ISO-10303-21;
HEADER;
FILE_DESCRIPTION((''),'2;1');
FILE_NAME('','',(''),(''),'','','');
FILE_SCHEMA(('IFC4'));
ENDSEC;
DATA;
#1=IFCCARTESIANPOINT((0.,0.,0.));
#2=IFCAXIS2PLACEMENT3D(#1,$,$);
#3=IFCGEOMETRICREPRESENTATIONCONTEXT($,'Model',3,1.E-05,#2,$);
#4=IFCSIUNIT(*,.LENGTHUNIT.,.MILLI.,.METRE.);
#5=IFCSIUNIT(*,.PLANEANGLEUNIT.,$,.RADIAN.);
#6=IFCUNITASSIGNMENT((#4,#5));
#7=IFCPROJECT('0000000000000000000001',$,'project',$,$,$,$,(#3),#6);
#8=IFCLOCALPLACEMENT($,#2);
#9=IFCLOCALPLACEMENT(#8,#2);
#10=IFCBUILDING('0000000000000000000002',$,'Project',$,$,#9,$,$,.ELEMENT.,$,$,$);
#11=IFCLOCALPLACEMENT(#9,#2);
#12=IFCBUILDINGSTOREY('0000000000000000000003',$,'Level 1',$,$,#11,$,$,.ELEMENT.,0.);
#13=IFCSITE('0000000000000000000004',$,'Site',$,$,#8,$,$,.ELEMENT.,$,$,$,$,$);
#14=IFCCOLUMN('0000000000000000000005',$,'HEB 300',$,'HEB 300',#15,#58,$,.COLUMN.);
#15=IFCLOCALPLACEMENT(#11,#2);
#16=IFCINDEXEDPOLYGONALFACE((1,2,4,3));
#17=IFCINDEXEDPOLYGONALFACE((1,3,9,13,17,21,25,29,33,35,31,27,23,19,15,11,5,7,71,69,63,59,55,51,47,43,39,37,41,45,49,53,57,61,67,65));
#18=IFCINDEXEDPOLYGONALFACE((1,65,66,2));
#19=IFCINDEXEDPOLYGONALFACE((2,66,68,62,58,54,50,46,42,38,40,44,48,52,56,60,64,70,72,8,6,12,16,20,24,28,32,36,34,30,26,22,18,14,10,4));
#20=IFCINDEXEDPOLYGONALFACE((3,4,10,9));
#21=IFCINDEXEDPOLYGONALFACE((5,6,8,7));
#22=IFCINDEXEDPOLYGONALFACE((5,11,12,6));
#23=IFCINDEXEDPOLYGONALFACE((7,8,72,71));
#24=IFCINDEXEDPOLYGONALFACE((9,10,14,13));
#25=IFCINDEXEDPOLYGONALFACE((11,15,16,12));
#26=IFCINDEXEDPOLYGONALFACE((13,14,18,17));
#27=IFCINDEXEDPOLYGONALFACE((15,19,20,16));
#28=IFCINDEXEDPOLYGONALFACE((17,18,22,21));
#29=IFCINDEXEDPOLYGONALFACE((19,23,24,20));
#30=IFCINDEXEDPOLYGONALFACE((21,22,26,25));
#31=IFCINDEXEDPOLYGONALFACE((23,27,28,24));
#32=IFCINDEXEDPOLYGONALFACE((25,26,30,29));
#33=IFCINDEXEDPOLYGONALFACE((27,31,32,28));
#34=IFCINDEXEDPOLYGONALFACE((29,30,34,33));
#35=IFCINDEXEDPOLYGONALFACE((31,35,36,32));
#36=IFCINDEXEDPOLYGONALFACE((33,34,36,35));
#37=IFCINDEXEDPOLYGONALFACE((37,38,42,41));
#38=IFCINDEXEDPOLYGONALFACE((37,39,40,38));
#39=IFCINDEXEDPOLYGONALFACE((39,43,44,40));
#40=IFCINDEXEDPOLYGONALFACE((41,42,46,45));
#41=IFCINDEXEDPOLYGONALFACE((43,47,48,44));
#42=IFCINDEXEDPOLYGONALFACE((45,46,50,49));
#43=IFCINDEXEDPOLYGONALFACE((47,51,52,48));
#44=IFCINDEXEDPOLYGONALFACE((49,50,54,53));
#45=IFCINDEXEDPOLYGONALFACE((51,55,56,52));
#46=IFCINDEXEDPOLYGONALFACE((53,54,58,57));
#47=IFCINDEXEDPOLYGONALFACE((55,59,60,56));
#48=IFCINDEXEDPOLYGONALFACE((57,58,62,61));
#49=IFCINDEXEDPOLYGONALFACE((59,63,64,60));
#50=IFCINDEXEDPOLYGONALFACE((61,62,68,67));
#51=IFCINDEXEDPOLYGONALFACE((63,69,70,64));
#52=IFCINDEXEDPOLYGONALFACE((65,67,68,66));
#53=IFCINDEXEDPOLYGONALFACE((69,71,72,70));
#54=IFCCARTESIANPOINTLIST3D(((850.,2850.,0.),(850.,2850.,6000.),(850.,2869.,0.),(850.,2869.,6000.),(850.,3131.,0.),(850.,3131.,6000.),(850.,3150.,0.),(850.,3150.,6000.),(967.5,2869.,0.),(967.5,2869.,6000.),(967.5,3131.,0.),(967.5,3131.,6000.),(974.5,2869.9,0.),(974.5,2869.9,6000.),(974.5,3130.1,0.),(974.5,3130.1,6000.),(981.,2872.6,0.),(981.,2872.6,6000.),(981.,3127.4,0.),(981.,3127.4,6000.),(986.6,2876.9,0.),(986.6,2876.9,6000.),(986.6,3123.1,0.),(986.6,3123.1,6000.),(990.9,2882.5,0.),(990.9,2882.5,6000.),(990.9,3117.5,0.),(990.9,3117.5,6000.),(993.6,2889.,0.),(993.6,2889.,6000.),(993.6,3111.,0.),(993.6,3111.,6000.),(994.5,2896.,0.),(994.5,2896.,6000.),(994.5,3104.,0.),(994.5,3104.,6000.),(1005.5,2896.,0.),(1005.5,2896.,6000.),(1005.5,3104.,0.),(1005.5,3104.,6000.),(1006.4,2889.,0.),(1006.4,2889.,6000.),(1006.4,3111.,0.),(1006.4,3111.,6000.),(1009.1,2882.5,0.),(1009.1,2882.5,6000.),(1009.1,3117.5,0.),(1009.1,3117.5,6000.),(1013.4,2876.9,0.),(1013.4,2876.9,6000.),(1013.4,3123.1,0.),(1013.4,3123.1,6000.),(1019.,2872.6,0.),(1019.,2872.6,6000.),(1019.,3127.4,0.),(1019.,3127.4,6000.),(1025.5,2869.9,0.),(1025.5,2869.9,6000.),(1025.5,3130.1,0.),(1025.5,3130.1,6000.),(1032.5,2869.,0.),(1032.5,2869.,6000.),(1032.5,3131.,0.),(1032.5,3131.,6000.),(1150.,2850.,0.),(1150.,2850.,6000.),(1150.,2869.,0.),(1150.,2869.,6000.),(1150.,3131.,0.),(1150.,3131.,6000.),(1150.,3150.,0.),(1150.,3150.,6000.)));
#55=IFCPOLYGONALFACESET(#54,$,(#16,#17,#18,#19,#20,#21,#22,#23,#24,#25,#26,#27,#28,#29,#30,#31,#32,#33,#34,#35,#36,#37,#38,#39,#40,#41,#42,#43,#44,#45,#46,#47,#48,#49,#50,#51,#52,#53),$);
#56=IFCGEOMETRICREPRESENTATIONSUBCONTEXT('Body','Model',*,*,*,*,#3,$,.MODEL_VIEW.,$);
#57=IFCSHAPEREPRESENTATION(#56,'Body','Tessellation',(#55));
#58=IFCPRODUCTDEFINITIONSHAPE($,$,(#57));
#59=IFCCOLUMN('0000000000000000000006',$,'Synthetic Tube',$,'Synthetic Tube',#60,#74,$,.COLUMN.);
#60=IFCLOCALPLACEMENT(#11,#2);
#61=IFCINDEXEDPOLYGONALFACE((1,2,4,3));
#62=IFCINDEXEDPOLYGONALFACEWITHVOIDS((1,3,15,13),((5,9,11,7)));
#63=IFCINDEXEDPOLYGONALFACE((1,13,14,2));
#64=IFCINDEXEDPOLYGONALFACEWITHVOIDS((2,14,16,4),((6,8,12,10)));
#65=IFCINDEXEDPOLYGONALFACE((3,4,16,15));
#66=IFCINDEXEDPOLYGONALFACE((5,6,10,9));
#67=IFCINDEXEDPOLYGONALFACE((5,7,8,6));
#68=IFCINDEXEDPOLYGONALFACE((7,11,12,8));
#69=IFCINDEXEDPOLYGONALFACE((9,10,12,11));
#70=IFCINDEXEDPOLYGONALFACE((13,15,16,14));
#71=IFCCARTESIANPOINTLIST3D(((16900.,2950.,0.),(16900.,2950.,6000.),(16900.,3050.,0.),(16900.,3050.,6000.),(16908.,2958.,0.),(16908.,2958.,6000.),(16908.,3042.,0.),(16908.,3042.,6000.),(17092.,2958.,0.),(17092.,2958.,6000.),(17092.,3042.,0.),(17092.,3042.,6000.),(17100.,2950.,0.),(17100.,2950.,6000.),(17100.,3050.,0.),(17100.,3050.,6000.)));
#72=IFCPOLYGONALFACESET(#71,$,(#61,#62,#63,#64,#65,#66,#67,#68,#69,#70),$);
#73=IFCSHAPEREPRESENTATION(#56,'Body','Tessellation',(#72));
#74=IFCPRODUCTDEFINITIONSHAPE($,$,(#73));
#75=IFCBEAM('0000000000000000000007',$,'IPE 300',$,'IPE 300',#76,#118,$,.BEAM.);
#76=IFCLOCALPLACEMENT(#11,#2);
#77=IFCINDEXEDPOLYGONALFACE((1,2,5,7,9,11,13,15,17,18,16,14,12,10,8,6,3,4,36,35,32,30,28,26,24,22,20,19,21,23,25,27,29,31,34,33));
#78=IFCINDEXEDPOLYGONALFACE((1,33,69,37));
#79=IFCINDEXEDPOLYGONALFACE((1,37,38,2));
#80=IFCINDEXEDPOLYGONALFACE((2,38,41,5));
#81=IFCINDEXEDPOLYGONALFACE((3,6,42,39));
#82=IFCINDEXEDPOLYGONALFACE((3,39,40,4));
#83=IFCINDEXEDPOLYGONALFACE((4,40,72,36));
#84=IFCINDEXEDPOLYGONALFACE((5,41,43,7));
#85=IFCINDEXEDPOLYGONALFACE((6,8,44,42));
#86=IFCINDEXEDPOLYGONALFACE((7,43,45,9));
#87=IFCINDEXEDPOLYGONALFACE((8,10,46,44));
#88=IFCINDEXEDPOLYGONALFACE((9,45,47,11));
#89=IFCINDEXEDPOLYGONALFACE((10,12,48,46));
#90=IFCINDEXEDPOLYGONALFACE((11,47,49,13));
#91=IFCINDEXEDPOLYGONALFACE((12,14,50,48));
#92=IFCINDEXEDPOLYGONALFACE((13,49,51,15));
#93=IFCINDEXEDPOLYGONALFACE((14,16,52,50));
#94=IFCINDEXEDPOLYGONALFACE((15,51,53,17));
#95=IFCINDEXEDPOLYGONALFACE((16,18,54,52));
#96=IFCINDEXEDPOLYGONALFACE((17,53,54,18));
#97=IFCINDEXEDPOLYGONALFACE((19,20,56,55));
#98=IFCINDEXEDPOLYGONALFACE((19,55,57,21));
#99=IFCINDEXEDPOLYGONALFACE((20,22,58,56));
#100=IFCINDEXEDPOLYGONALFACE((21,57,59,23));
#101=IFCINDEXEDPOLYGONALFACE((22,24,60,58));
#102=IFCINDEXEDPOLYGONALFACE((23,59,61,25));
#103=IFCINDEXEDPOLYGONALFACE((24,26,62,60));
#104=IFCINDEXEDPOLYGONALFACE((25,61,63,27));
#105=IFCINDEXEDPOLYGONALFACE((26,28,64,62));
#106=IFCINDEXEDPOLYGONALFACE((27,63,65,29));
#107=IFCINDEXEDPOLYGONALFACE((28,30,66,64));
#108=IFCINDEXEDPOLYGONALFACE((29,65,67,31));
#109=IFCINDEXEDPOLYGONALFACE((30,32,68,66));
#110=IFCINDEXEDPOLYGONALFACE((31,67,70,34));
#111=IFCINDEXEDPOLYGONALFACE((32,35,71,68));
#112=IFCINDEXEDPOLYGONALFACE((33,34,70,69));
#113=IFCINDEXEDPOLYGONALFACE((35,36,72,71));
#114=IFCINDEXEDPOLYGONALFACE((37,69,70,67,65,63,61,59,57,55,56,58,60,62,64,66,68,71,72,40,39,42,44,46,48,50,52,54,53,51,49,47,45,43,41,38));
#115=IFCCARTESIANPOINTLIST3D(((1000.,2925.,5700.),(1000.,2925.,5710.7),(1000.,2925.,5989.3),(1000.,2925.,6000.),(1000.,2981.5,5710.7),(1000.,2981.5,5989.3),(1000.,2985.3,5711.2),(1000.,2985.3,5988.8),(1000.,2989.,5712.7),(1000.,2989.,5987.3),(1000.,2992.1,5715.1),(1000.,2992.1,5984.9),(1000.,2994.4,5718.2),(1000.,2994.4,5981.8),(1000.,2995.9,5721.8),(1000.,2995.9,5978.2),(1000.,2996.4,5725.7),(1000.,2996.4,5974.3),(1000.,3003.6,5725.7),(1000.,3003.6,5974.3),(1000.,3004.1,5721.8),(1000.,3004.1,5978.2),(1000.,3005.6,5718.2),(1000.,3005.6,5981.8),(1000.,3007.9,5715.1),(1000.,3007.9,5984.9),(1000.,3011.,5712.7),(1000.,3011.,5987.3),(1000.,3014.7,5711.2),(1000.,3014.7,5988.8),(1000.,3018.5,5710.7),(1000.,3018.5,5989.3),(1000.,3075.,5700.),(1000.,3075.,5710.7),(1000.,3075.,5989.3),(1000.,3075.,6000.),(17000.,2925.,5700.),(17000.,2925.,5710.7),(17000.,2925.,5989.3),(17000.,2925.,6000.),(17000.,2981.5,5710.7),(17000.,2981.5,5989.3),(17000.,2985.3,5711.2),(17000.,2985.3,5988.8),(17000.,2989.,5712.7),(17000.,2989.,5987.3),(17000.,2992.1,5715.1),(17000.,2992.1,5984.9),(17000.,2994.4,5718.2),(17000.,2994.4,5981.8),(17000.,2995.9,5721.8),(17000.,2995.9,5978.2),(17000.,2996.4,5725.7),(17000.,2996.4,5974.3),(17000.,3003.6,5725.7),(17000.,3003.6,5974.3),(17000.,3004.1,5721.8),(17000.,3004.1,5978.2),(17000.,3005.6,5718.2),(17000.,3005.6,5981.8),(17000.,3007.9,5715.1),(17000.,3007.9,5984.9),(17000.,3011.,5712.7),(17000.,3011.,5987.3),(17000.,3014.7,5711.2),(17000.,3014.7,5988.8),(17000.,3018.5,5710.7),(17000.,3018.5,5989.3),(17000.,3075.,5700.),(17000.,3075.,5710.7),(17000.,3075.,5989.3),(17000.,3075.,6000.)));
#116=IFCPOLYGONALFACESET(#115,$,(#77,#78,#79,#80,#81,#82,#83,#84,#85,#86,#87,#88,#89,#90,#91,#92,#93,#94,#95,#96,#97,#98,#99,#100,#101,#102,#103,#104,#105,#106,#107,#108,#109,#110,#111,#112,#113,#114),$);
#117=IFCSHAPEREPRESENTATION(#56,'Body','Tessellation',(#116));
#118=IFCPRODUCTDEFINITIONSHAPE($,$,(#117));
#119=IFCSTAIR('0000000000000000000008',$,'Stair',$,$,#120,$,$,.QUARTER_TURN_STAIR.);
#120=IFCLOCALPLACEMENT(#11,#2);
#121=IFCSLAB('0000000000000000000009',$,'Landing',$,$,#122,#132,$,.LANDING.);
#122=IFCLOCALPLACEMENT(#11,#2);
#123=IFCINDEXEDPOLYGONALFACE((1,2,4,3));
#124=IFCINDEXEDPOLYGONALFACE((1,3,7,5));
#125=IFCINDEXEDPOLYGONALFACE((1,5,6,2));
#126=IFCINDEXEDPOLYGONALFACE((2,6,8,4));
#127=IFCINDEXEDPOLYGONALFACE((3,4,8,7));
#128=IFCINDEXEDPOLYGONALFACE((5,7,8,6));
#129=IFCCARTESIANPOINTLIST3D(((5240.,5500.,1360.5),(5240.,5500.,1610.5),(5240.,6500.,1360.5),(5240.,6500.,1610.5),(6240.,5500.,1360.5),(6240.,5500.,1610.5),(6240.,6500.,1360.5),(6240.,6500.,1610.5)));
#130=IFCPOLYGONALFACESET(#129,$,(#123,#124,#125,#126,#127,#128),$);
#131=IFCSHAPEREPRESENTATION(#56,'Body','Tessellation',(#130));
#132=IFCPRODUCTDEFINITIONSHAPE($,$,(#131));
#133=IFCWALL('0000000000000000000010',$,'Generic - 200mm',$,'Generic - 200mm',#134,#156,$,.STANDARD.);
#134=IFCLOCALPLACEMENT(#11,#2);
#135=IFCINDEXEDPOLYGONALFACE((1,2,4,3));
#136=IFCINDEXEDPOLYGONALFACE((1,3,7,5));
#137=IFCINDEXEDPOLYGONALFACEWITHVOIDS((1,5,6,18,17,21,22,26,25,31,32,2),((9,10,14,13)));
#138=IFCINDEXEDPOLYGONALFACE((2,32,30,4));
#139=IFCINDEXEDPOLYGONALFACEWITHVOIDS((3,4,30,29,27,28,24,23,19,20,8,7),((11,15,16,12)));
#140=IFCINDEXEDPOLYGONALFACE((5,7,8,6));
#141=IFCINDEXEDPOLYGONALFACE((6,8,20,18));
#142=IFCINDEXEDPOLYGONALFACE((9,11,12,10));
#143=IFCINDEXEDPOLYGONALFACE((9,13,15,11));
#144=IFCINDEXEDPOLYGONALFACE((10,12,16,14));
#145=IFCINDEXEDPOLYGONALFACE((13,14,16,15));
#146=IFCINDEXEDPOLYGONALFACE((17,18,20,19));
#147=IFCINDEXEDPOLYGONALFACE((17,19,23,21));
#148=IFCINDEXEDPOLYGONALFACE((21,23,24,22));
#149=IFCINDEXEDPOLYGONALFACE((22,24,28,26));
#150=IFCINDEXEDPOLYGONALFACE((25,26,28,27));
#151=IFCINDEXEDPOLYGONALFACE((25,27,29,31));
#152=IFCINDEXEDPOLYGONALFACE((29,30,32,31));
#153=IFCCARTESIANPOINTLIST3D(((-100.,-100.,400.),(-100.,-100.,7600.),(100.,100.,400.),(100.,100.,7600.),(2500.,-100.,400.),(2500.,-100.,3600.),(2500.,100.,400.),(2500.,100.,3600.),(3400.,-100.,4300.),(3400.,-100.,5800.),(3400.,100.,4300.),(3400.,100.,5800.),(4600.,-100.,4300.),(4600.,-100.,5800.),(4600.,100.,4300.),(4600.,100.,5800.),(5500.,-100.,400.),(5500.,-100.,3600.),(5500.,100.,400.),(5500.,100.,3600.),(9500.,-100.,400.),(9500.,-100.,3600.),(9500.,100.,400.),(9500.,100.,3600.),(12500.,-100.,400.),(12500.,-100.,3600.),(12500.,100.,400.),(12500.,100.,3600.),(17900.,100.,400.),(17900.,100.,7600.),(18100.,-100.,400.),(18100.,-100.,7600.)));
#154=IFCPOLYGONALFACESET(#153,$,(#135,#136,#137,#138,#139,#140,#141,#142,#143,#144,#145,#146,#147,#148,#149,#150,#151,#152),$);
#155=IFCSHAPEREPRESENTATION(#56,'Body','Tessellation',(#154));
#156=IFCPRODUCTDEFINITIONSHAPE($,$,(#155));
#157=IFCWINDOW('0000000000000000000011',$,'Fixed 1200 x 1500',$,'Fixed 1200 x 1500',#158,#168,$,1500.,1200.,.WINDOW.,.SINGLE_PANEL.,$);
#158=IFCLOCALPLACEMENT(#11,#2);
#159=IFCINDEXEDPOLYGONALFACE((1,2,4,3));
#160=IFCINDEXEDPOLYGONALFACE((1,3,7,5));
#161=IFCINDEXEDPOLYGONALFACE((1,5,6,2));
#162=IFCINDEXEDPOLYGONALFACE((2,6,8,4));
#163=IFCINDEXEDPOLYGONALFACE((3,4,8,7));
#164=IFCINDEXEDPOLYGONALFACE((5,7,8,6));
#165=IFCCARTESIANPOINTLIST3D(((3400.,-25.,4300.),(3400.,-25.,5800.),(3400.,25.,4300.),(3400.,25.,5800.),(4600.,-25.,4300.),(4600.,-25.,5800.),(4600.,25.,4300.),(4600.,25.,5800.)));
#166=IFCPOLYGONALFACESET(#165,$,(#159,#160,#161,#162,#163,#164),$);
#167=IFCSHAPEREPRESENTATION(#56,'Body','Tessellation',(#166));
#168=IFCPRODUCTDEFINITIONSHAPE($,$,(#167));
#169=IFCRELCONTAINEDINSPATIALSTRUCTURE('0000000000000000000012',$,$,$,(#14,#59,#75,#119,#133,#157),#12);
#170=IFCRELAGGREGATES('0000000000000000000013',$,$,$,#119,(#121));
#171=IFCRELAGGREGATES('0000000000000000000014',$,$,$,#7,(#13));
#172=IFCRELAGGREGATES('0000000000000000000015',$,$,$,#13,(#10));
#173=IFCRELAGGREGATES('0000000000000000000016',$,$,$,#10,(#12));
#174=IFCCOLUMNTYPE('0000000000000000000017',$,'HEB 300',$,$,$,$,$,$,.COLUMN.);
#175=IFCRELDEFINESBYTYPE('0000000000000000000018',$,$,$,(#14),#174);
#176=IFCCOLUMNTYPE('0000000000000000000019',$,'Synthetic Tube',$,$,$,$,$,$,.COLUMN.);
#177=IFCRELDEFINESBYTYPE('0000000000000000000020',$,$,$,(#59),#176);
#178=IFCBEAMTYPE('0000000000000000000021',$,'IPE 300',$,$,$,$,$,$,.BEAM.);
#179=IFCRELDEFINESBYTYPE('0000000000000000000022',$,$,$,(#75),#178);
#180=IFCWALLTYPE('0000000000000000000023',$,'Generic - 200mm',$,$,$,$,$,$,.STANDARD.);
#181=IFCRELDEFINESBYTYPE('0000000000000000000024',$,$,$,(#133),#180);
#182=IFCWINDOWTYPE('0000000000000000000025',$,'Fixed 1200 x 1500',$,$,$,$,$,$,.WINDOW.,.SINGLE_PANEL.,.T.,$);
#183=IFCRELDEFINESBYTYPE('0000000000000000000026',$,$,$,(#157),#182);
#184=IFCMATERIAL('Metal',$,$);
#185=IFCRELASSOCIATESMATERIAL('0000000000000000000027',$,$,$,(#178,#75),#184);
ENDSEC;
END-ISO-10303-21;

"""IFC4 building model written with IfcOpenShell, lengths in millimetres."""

from ifc_helpers import new_model, si_unit, frame, frame_2d, origin, origin_2d, place, context, subcontext, project, spatial, polyline, rectangle, hollow_rectangle, i_section, outline, extrude, material, material_profile, profile_set, profile_usage, type_object, element, fill, aggregate, save


model = new_model("IFC4")

# Units and contexts
model_context = context("Model", 3, precision=1e-05, world=origin())
body_context = subcontext(model_context, "Body", "Model", "MODEL_VIEW")
ifc_project = project(units=[si_unit("LENGTHUNIT", "METRE", prefix="MILLI"), si_unit("PLANEANGLEUNIT", "RADIAN")], contexts=[model_context])

# Site, building, storey
site_placement = place(None, origin())
site = spatial("IfcSite", under=ifc_project, at=site_placement, Name="Site", CompositionType="ELEMENT")
building_placement = place(site_placement, origin())
building = spatial("IfcBuilding", under=site, at=building_placement, Name="Project", CompositionType="ELEMENT")
storey_placement = place(building_placement, origin())
storey = spatial("IfcBuildingStorey", under=building, at=storey_placement, Name="Level 1", CompositionType="ELEMENT", Elevation=0.0)

# Columns
ifc_material_profile_1 = material_profile(None, i_section(OverallWidth=300.0, OverallDepth=300.0, WebThickness=11.0, FlangeThickness=19.0, FilletRadius=27.0, at=origin_2d()), Name="HEB 300")
ifc_profile_set_1 = profile_set([ifc_material_profile_1], Name="HEB 300")
ifc_profile_usage_1 = profile_usage(ifc_profile_set_1, cardinal=5)
column_type_1 = type_object("IfcColumnType", Name="HEB 300", PredefinedType="COLUMN", material=ifc_profile_set_1)
column_1_placement = place(storey_placement, frame((1000.0, 3000.0, 0.0), z_axis=(0.0, 0.0, 1.0), x_axis=(1.0, 0.0, 0.0)))
element("IfcColumn", 1, at=column_1_placement, inside=storey, type_object=column_type_1, material=ifc_profile_usage_1, Name="HEB 300", ObjectType="HEB 300", PredefinedType="COLUMN", context=body_context, shape_type="SweptSolid", body=[
    extrude(i_section(OverallWidth=300.0, OverallDepth=300.0, WebThickness=11.0, FlangeThickness=19.0, FilletRadius=27.0, at=origin_2d()), origin(), (0.0, 0.0, 1.0), 6000.0),
])
ifc_material_profile_2 = material_profile(None, hollow_rectangle(XDim=200.0, YDim=100.0, WallThickness=8.0, at=origin_2d()), Name="Synthetic Tube")
ifc_profile_set_2 = profile_set([ifc_material_profile_2], Name="Synthetic Tube")
ifc_profile_usage_2 = profile_usage(ifc_profile_set_2, cardinal=5)
column_type_2 = type_object("IfcColumnType", Name="Synthetic Tube", PredefinedType="COLUMN", material=ifc_profile_set_2)
column_2_placement = place(storey_placement, frame((17000.0, 3000.0, 0.0), z_axis=(0.0, 0.0, 1.0), x_axis=(1.0, 0.0, 0.0)))
element("IfcColumn", 2, at=column_2_placement, inside=storey, type_object=column_type_2, material=ifc_profile_usage_2, Name="Synthetic Tube", ObjectType="Synthetic Tube", PredefinedType="COLUMN", context=body_context, shape_type="SweptSolid", body=[
    extrude(hollow_rectangle(XDim=200.0, YDim=100.0, WallThickness=8.0, at=origin_2d()), origin(), (0.0, 0.0, 1.0), 6000.0),
])

# Beam
ifc_material = material(Name="Metal")
ifc_material_profile_3 = material_profile(ifc_material, i_section(OverallWidth=150.0, OverallDepth=300.0, WebThickness=7.1, FlangeThickness=10.7, FilletRadius=15.0, at=origin_2d()), Name="IPE 300")
ifc_profile_set_3 = profile_set([ifc_material_profile_3], Name="IPE 300")
ifc_profile_usage_3 = profile_usage(ifc_profile_set_3, cardinal=8)
beam_type = type_object("IfcBeamType", Name="IPE 300", PredefinedType="BEAM", material=ifc_profile_set_3)
beam_placement = place(storey_placement, frame((1000.0, 3000.0, 5850.0)))
element("IfcBeam", 3, at=beam_placement, inside=storey, type_object=beam_type, material=ifc_profile_usage_3, Name="IPE 300", ObjectType="IPE 300", PredefinedType="BEAM", context=body_context, shape_type="SweptSolid", body=[
    extrude(i_section(OverallWidth=150.0, OverallDepth=300.0, WebThickness=7.1, FlangeThickness=10.7, FilletRadius=15.0, at=origin_2d()), frame((0.0, 0.0, 0.0), z_axis=(1.0, 0.0, 0.0), x_axis=(0.0, 1.0, 0.0)), (0.0, 0.0, 1.0), 16000.0),
])

# Stair, slab
stair_placement = place(storey_placement, origin())
stair = element("IfcStair", 4, at=stair_placement, inside=storey, Name="Stair", PredefinedType="QUARTER_TURN_STAIR")
slab_placement = place(stair_placement, origin())
slab = element("IfcSlab", 5, at=slab_placement, Name="Landing", PredefinedType="LANDING", context=body_context, shape_type="SweptSolid", body=[
    extrude(outline(polyline([(5240.0, 5500.0), (6240.0, 5500.0), (6240.0, 6500.0), (5240.0, 6500.0), (5240.0, 5500.0)])), frame((0.0, 0.0, 1360.5)), (0.0, 0.0, 1.0), 250.0),
])
aggregate(stair, [slab])

# Wall, openings, window
wall_type = type_object("IfcWallType", Name="Generic - 200mm", PredefinedType="STANDARD")
wall_1_placement = place(storey_placement, frame((0.0, 0.0, 400.0), z_axis=(0.0, 0.0, 1.0), x_axis=(1.0, 0.0, 0.0)))
wall_1 = element("IfcWall", 6, at=wall_1_placement, inside=storey, type_object=wall_type, Name="Generic - 200mm", ObjectType="Generic - 200mm", PredefinedType="STANDARD", context=body_context, shape_type="SweptSolid", body=[
    extrude(outline(polyline([(-100.0, -100.0), (0.0, 0.0), (100.0, 100.0), (17900.0, 100.0), (18000.0, 0.0), (18100.0, -100.0), (-100.0, -100.0)])), origin(), (0.0, 0.0, 1.0), 7200.0),
])
opening_1_placement = place(wall_1_placement, frame((2500.0, 0.0, 0.0), z_axis=(0.0, 0.0, 1.0), x_axis=(1.0, 0.0, 0.0)))
element("IfcOpeningElement", 7, at=opening_1_placement, cuts=wall_1, PredefinedType="OPENING", context=body_context, shape_type="SweptSolid", body=[
    extrude(rectangle(XDim=3000.0, YDim=220.0, at=frame_2d((1500.0, 0.0))), origin(), (0.0, 0.0, 1.0), 3200.0),
])
opening_2_placement = place(wall_1_placement, frame((9500.0, 0.0, 0.0), z_axis=(0.0, 0.0, 1.0), x_axis=(1.0, 0.0, 0.0)))
element("IfcOpeningElement", 8, at=opening_2_placement, cuts=wall_1, PredefinedType="OPENING", context=body_context, shape_type="SweptSolid", body=[
    extrude(rectangle(XDim=3000.0, YDim=220.0, at=frame_2d((1500.0, 0.0))), origin(), (0.0, 0.0, 1.0), 3200.0),
])
opening_3_placement = place(wall_1_placement, frame((3400.0, 0.0, 3900.0), z_axis=(0.0, 0.0, 1.0), x_axis=(1.0, 0.0, 0.0)))
opening_3 = element("IfcOpeningElement", 9, at=opening_3_placement, cuts=wall_1, PredefinedType="OPENING", context=body_context, shape_type="SweptSolid", body=[
    extrude(rectangle(XDim=1200.0, YDim=220.0, at=frame_2d((600.0, 0.0))), origin(), (0.0, 0.0, 1.0), 1500.0),
])
window_type = type_object("IfcWindowType", Name="Fixed 1200 x 1500", ParameterTakesPrecedence=True, PartitioningType="SINGLE_PANEL", PredefinedType="WINDOW")
window_placement = place(opening_3_placement, origin())
window = element("IfcWindow", 10, at=window_placement, inside=storey, type_object=window_type, Name="Fixed 1200 x 1500", ObjectType="Fixed 1200 x 1500", OverallHeight=1500.0, OverallWidth=1200.0, PartitioningType="SINGLE_PANEL", PredefinedType="WINDOW", context=body_context, shape_type="SweptSolid", body=[
    extrude(rectangle(XDim=1200.0, YDim=50.0, at=frame_2d((600.0, 0.0))), origin(), (0.0, 0.0, 1.0), 1500.0),
])
fill(opening_3, window)

save(model, "model.ifc")
